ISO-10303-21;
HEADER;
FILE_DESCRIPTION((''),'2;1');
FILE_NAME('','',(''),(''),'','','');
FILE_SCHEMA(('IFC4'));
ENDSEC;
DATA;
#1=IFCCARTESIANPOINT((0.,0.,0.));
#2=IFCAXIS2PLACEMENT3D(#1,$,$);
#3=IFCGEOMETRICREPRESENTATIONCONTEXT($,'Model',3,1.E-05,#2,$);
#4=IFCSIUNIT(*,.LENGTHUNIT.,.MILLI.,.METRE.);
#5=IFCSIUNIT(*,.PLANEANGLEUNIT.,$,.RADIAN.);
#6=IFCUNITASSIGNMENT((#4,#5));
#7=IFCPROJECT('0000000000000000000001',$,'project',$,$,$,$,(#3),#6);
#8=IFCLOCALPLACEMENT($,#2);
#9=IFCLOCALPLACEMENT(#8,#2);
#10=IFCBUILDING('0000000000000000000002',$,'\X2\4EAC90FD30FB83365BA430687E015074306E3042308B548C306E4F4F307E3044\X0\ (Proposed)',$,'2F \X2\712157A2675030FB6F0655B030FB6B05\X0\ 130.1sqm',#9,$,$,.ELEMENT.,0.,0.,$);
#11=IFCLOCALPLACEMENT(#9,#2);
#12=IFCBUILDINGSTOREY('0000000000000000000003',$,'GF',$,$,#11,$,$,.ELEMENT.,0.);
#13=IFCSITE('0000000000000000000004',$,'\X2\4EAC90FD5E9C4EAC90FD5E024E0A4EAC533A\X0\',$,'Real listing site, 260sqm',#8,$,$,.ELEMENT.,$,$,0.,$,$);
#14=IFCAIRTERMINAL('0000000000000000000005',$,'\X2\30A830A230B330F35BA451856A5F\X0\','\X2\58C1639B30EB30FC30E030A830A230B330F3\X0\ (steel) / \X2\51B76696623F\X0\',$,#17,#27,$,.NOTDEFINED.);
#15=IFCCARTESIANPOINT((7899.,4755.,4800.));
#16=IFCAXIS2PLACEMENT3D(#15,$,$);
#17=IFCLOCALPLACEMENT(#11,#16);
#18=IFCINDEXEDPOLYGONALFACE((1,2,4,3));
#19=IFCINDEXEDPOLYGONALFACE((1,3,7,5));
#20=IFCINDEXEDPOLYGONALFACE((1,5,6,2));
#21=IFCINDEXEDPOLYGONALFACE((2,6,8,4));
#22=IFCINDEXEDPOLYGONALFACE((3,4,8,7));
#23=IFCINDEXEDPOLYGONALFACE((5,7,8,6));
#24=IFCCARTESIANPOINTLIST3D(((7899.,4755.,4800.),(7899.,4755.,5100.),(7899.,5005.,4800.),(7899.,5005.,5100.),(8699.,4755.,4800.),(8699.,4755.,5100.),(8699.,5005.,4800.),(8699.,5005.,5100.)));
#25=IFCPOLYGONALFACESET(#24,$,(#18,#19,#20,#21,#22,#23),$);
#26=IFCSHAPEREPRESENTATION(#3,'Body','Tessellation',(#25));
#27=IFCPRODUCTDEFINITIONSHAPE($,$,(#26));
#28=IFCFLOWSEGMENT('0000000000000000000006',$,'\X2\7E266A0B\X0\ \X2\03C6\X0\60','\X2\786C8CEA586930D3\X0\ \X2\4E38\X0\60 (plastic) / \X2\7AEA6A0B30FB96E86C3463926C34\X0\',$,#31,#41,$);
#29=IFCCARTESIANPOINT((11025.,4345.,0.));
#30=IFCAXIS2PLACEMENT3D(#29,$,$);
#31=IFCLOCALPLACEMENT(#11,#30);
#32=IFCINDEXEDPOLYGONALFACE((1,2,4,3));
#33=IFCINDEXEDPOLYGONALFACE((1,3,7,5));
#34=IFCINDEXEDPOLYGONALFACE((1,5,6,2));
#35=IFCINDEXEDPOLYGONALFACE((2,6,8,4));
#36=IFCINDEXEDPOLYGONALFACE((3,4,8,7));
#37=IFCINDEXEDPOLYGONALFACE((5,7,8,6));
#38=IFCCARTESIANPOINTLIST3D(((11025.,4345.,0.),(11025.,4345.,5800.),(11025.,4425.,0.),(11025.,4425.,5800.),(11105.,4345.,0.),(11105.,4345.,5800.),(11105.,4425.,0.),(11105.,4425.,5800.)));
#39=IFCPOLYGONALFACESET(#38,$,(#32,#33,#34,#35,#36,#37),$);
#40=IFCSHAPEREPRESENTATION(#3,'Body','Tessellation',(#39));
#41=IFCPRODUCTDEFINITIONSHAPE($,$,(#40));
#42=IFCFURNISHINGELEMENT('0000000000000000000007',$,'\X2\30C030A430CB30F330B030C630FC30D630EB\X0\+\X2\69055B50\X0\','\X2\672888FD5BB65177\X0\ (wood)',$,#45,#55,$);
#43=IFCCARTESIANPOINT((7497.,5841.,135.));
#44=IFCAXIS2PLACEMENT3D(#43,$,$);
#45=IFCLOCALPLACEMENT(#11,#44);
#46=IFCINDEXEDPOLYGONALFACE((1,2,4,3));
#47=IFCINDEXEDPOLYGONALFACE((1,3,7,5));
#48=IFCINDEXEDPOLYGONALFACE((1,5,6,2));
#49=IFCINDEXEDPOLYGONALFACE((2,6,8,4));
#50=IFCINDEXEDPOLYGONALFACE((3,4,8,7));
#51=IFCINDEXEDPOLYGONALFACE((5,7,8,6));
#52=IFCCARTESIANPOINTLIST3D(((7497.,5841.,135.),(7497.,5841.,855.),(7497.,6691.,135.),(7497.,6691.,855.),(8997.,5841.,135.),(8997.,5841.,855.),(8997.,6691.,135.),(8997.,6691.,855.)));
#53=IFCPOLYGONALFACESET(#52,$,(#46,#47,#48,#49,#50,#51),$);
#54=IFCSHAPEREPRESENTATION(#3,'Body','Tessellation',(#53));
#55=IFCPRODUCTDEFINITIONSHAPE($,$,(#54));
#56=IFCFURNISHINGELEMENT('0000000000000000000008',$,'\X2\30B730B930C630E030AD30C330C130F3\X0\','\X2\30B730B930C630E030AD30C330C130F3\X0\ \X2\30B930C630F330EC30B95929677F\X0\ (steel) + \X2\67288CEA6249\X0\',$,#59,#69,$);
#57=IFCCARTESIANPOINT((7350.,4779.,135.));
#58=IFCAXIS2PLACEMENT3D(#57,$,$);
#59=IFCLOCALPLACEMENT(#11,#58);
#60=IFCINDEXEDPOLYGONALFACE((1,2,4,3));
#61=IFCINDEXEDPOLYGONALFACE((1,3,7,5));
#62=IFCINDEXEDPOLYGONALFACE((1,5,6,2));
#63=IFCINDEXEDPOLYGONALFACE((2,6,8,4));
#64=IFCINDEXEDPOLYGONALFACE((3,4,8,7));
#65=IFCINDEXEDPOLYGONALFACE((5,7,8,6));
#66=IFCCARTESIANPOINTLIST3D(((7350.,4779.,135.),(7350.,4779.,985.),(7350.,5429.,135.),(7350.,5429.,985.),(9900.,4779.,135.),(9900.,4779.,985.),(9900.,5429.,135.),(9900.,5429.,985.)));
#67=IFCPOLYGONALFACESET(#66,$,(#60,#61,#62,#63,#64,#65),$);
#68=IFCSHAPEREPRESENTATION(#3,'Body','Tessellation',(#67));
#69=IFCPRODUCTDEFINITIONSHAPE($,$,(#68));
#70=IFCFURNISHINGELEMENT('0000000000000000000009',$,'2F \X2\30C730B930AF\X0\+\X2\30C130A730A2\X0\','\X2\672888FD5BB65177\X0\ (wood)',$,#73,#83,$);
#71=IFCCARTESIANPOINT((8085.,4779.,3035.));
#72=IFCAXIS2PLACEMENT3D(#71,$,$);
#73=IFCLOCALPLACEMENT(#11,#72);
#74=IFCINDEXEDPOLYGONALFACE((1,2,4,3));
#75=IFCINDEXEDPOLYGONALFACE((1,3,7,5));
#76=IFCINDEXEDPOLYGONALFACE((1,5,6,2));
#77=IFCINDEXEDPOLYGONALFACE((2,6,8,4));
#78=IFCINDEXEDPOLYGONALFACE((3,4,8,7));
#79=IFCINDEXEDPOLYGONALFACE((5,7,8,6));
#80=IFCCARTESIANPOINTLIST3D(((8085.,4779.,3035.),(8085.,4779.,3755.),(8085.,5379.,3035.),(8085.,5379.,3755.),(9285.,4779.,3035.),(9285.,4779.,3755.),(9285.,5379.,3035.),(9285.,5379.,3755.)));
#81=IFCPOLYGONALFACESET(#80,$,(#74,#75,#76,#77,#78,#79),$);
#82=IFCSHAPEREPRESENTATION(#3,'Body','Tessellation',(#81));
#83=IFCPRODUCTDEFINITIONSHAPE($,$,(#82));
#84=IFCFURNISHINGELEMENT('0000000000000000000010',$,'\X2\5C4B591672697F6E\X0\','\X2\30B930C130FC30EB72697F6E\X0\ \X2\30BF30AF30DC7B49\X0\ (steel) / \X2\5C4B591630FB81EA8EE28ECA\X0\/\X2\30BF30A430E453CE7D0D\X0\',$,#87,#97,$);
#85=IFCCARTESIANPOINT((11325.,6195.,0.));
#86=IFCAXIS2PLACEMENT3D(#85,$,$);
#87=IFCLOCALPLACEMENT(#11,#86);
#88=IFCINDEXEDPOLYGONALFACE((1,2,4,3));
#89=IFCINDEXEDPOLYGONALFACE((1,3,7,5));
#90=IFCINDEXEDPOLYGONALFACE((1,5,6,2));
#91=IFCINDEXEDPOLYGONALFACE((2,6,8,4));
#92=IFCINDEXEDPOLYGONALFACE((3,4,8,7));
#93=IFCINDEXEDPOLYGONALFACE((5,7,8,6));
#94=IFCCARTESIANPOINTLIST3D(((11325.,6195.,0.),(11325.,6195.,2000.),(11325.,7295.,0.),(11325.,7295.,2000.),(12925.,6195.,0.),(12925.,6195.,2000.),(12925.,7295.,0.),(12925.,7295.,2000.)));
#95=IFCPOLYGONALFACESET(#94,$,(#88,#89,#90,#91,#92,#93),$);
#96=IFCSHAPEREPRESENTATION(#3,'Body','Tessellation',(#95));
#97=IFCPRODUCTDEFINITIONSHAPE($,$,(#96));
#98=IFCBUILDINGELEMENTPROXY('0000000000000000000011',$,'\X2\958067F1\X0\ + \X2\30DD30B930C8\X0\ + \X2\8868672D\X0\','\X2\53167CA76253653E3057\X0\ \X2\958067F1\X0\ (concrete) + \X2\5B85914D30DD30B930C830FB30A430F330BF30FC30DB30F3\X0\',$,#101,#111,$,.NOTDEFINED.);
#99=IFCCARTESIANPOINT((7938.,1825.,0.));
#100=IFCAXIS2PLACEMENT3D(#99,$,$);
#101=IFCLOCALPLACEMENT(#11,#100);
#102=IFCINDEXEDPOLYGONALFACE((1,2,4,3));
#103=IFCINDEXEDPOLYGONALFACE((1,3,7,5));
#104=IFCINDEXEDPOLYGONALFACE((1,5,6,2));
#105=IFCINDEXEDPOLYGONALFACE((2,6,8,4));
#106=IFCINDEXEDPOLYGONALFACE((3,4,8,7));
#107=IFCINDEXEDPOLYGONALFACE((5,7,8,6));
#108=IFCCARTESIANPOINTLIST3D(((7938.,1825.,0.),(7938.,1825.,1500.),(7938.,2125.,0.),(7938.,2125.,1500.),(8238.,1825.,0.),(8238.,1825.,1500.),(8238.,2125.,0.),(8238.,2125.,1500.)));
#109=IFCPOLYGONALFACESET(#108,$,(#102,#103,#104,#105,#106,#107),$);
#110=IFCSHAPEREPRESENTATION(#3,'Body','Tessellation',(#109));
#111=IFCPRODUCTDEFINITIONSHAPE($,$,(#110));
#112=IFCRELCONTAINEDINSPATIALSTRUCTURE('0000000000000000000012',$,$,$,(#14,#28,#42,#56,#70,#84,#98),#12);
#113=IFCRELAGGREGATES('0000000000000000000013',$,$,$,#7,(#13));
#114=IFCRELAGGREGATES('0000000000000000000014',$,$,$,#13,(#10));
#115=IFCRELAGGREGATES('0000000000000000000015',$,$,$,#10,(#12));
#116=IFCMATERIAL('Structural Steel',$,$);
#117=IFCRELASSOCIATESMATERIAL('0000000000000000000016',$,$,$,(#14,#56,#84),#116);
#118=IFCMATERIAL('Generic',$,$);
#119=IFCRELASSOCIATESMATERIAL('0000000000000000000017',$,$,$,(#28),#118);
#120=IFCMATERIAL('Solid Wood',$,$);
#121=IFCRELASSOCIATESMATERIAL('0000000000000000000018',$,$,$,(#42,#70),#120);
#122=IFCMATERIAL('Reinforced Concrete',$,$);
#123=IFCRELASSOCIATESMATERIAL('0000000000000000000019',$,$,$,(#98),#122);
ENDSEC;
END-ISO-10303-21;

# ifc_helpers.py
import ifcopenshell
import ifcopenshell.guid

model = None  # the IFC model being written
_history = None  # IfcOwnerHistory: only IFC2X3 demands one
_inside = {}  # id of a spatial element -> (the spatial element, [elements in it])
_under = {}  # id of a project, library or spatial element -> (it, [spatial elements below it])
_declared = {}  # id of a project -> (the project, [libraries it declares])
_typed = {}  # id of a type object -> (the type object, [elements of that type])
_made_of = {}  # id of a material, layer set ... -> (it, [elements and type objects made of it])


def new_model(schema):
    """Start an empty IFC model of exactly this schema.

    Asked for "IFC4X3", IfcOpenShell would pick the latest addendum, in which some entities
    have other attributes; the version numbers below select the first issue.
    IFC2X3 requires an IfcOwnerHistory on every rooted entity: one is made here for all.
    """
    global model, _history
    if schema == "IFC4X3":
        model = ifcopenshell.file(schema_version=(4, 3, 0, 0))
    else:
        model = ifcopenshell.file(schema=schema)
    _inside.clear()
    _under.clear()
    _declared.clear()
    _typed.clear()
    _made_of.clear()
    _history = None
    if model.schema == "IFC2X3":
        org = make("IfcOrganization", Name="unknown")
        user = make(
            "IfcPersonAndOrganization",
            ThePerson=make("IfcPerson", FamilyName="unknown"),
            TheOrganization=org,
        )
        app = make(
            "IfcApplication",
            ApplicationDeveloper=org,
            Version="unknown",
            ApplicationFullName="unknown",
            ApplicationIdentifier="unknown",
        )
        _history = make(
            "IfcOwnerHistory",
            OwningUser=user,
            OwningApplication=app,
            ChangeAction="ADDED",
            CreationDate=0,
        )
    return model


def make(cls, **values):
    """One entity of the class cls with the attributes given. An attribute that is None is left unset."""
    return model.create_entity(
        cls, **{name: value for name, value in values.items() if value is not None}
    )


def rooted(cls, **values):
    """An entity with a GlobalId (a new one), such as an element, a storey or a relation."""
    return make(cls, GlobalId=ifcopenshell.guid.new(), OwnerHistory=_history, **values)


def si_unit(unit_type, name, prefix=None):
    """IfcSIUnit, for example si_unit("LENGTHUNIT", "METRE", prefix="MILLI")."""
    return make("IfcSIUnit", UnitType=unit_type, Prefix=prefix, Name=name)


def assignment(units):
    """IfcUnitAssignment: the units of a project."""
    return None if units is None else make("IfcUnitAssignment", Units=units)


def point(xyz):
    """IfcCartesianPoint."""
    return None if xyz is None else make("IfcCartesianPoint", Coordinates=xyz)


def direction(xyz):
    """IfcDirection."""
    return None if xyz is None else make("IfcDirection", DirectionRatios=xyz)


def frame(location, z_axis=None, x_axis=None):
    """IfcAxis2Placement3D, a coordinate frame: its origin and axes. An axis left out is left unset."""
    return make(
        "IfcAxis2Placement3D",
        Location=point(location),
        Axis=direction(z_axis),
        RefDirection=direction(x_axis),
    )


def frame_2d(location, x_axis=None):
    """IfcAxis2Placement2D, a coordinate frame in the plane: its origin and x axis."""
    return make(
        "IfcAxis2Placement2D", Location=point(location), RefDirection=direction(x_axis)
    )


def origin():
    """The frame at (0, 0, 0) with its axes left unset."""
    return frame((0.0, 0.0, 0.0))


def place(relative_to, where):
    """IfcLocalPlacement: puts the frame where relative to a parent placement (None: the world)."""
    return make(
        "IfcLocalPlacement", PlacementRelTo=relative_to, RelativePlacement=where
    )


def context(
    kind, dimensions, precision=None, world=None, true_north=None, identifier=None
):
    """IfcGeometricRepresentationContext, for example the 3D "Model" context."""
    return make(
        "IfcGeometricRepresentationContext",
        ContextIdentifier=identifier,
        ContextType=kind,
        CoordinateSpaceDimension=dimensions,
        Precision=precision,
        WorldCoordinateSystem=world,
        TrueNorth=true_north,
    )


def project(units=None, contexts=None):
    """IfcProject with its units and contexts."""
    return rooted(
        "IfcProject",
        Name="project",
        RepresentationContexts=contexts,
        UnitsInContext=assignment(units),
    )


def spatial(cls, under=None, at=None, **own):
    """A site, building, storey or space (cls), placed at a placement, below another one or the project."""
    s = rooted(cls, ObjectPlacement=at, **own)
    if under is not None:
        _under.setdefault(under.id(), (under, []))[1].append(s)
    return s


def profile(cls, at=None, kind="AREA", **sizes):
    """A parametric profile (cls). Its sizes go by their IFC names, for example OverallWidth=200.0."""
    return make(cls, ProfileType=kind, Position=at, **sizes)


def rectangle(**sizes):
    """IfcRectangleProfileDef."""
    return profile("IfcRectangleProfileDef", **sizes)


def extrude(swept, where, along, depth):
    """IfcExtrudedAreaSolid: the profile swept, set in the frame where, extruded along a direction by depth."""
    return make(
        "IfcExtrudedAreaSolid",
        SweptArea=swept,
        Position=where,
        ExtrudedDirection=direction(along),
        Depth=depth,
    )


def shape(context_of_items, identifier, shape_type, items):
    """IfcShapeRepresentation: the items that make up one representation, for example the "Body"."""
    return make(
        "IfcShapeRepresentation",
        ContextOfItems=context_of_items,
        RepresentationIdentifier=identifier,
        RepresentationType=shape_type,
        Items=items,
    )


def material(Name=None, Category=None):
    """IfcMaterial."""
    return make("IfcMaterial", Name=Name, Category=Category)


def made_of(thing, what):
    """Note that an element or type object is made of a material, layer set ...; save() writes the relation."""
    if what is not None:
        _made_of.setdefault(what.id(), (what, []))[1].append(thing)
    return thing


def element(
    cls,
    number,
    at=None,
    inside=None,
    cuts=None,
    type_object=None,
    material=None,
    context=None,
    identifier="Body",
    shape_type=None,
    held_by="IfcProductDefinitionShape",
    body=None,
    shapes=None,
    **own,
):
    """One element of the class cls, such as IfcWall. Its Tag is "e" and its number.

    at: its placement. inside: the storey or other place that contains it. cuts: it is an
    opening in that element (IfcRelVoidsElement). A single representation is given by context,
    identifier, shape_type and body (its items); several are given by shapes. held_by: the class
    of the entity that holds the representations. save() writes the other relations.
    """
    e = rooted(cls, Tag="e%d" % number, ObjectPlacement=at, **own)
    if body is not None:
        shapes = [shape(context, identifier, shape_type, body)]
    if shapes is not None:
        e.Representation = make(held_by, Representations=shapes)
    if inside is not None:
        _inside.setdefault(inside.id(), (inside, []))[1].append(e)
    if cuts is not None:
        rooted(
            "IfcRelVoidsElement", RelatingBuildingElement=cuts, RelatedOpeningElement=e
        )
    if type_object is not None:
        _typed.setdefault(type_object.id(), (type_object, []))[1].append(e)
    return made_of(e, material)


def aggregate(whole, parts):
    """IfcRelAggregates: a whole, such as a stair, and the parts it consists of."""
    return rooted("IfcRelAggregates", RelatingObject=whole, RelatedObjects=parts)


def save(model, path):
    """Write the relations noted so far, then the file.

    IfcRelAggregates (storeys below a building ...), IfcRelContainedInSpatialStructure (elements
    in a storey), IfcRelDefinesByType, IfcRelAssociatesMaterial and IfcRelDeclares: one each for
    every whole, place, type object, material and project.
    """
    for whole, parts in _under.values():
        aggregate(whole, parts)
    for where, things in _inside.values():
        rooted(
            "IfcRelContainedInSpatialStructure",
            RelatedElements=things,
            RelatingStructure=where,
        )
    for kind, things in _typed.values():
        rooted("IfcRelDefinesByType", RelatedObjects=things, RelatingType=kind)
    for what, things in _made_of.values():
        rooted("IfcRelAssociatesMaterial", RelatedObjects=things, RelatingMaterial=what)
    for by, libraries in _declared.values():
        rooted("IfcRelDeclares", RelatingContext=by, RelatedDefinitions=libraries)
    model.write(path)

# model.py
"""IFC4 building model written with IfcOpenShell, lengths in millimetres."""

from ifc_helpers import new_model, si_unit, frame, frame_2d, origin, place, context, project, spatial, rectangle, extrude, material, element, save


model = new_model("IFC4")

# Units and contexts
model_context = context("Model", 3, precision=1e-05, world=origin())
ifc_project = project(units=[si_unit("LENGTHUNIT", "METRE", prefix="MILLI"), si_unit("PLANEANGLEUNIT", "RADIAN")], contexts=[model_context])

# Site, building, storey
site_placement = place(None, origin())
site = spatial("IfcSite", under=ifc_project, at=site_placement, Name="京都府京都市上京区", ObjectType="Real listing site, 260sqm", CompositionType="ELEMENT", RefElevation=0.0)
building_placement = place(site_placement, origin())
building = spatial("IfcBuilding", under=site, at=building_placement, Name="京都・茶室と縁側のある和の住まい (Proposed)", ObjectType="2F 無垢材・漆喰・欅 130.1sqm", CompositionType="ELEMENT", ElevationOfRefHeight=0.0, ElevationOfTerrain=0.0)
storey_placement = place(building_placement, origin())
storey = spatial("IfcBuildingStorey", under=building, at=storey_placement, Name="GF", CompositionType="ELEMENT", Elevation=0.0)

# Shared definitions
ifc_material_1 = material(Name="Solid Wood")

# Shared definitions
ifc_material_2 = material(Name="Reinforced Concrete")

# Shared definitions
ifc_material_3 = material(Name="Structural Steel")

# Shared definitions
ifc_material_4 = material(Name="Generic")

# Air terminal
air_terminal_placement = place(storey_placement, frame((7899.0, 4755.0, 4800.0)))
element("IfcAirTerminal", 1, at=air_terminal_placement, inside=storey, material=ifc_material_3, Name="エアコン室内機", Description="壁掛ルームエアコン (steel) / 冷暖房", PredefinedType="NOTDEFINED", context=model_context, shape_type="SweptSolid", body=[
    extrude(rectangle(XDim=800.0, YDim=250.0, at=frame_2d((400.0, 125.0))), frame((7899.0, 4755.0, 4800.0)), (0.0, 0.0, 1.0), 300.0),
])

# Flow segment
flow_segment_placement = place(storey_placement, frame((11025.0, 4345.0, 0.0)))
element("IfcFlowSegment", 2, at=flow_segment_placement, inside=storey, material=ifc_material_4, Name="縦樋 φ60", Description="硬質塩ビ 丸60 (plastic) / 竪樋・雨水排水", context=model_context, shape_type="SweptSolid", body=[
    extrude(rectangle(XDim=80.0, YDim=80.0, at=frame_2d((40.0, 40.0))), frame((11025.0, 4345.0, 0.0)), (0.0, 0.0, 1.0), 5800.0),
])

# Furnishing elements
furnishing_1_placement = place(storey_placement, frame((7497.0, 5841.0, 135.0)))
element("IfcFurnishingElement", 3, at=furnishing_1_placement, inside=storey, material=ifc_material_1, Name="ダイニングテーブル+椅子", Description="木製家具 (wood)", context=model_context, shape_type="SweptSolid", body=[
    extrude(rectangle(XDim=1500.0, YDim=850.0, at=frame_2d((750.0, 425.0))), frame((7497.0, 5841.0, 135.0)), (0.0, 0.0, 1.0), 720.0),
])
furnishing_2_placement = place(storey_placement, frame((7350.0, 4779.0, 135.0)))
element("IfcFurnishingElement", 4, at=furnishing_2_placement, inside=storey, material=ifc_material_3, Name="システムキッチン", Description="システムキッチン ステンレス天板 (steel) + 木質扉", context=model_context, shape_type="SweptSolid", body=[
    extrude(rectangle(XDim=2550.0, YDim=650.0, at=frame_2d((1275.0, 325.0))), frame((7350.0, 4779.0, 135.0)), (0.0, 0.0, 1.0), 850.0),
])
furnishing_3_placement = place(storey_placement, frame((8085.0, 4779.0, 3035.0)))
element("IfcFurnishingElement", 5, at=furnishing_3_placement, inside=storey, material=ifc_material_1, Name="2F デスク+チェア", Description="木製家具 (wood)", context=model_context, shape_type="SweptSolid", body=[
    extrude(rectangle(XDim=1200.0, YDim=600.0, at=frame_2d((600.0, 300.0))), frame((8085.0, 4779.0, 3035.0)), (0.0, 0.0, 1.0), 720.0),
])
furnishing_4_placement = place(storey_placement, frame((11325.0, 6195.0, 0.0)))
element("IfcFurnishingElement", 6, at=furnishing_4_placement, inside=storey, material=ifc_material_3, Name="屋外物置", Description="スチール物置 タクボ等 (steel) / 屋外・自転車/タイヤ収納", context=model_context, shape_type="SweptSolid", body=[
    extrude(rectangle(XDim=1600.0, YDim=1100.0, at=frame_2d((800.0, 550.0))), frame((11325.0, 6195.0, 0.0)), (0.0, 0.0, 1.0), 2000.0),
])

# Building element proxy
proxy_placement = place(storey_placement, frame((7938.0, 1825.0, 0.0)))
element("IfcBuildingElementProxy", 7, at=proxy_placement, inside=storey, material=ifc_material_2, Name="門柱 + ポスト + 表札", Description="化粧打放し 門柱 (concrete) + 宅配ポスト・インターホン", PredefinedType="NOTDEFINED", context=model_context, shape_type="SweptSolid", body=[
    extrude(rectangle(XDim=300.0, YDim=300.0, at=frame_2d((150.0, 150.0))), frame((7938.0, 1825.0, 0.0)), (0.0, 0.0, 1.0), 1500.0),
])

save(model, "model.ifc")
